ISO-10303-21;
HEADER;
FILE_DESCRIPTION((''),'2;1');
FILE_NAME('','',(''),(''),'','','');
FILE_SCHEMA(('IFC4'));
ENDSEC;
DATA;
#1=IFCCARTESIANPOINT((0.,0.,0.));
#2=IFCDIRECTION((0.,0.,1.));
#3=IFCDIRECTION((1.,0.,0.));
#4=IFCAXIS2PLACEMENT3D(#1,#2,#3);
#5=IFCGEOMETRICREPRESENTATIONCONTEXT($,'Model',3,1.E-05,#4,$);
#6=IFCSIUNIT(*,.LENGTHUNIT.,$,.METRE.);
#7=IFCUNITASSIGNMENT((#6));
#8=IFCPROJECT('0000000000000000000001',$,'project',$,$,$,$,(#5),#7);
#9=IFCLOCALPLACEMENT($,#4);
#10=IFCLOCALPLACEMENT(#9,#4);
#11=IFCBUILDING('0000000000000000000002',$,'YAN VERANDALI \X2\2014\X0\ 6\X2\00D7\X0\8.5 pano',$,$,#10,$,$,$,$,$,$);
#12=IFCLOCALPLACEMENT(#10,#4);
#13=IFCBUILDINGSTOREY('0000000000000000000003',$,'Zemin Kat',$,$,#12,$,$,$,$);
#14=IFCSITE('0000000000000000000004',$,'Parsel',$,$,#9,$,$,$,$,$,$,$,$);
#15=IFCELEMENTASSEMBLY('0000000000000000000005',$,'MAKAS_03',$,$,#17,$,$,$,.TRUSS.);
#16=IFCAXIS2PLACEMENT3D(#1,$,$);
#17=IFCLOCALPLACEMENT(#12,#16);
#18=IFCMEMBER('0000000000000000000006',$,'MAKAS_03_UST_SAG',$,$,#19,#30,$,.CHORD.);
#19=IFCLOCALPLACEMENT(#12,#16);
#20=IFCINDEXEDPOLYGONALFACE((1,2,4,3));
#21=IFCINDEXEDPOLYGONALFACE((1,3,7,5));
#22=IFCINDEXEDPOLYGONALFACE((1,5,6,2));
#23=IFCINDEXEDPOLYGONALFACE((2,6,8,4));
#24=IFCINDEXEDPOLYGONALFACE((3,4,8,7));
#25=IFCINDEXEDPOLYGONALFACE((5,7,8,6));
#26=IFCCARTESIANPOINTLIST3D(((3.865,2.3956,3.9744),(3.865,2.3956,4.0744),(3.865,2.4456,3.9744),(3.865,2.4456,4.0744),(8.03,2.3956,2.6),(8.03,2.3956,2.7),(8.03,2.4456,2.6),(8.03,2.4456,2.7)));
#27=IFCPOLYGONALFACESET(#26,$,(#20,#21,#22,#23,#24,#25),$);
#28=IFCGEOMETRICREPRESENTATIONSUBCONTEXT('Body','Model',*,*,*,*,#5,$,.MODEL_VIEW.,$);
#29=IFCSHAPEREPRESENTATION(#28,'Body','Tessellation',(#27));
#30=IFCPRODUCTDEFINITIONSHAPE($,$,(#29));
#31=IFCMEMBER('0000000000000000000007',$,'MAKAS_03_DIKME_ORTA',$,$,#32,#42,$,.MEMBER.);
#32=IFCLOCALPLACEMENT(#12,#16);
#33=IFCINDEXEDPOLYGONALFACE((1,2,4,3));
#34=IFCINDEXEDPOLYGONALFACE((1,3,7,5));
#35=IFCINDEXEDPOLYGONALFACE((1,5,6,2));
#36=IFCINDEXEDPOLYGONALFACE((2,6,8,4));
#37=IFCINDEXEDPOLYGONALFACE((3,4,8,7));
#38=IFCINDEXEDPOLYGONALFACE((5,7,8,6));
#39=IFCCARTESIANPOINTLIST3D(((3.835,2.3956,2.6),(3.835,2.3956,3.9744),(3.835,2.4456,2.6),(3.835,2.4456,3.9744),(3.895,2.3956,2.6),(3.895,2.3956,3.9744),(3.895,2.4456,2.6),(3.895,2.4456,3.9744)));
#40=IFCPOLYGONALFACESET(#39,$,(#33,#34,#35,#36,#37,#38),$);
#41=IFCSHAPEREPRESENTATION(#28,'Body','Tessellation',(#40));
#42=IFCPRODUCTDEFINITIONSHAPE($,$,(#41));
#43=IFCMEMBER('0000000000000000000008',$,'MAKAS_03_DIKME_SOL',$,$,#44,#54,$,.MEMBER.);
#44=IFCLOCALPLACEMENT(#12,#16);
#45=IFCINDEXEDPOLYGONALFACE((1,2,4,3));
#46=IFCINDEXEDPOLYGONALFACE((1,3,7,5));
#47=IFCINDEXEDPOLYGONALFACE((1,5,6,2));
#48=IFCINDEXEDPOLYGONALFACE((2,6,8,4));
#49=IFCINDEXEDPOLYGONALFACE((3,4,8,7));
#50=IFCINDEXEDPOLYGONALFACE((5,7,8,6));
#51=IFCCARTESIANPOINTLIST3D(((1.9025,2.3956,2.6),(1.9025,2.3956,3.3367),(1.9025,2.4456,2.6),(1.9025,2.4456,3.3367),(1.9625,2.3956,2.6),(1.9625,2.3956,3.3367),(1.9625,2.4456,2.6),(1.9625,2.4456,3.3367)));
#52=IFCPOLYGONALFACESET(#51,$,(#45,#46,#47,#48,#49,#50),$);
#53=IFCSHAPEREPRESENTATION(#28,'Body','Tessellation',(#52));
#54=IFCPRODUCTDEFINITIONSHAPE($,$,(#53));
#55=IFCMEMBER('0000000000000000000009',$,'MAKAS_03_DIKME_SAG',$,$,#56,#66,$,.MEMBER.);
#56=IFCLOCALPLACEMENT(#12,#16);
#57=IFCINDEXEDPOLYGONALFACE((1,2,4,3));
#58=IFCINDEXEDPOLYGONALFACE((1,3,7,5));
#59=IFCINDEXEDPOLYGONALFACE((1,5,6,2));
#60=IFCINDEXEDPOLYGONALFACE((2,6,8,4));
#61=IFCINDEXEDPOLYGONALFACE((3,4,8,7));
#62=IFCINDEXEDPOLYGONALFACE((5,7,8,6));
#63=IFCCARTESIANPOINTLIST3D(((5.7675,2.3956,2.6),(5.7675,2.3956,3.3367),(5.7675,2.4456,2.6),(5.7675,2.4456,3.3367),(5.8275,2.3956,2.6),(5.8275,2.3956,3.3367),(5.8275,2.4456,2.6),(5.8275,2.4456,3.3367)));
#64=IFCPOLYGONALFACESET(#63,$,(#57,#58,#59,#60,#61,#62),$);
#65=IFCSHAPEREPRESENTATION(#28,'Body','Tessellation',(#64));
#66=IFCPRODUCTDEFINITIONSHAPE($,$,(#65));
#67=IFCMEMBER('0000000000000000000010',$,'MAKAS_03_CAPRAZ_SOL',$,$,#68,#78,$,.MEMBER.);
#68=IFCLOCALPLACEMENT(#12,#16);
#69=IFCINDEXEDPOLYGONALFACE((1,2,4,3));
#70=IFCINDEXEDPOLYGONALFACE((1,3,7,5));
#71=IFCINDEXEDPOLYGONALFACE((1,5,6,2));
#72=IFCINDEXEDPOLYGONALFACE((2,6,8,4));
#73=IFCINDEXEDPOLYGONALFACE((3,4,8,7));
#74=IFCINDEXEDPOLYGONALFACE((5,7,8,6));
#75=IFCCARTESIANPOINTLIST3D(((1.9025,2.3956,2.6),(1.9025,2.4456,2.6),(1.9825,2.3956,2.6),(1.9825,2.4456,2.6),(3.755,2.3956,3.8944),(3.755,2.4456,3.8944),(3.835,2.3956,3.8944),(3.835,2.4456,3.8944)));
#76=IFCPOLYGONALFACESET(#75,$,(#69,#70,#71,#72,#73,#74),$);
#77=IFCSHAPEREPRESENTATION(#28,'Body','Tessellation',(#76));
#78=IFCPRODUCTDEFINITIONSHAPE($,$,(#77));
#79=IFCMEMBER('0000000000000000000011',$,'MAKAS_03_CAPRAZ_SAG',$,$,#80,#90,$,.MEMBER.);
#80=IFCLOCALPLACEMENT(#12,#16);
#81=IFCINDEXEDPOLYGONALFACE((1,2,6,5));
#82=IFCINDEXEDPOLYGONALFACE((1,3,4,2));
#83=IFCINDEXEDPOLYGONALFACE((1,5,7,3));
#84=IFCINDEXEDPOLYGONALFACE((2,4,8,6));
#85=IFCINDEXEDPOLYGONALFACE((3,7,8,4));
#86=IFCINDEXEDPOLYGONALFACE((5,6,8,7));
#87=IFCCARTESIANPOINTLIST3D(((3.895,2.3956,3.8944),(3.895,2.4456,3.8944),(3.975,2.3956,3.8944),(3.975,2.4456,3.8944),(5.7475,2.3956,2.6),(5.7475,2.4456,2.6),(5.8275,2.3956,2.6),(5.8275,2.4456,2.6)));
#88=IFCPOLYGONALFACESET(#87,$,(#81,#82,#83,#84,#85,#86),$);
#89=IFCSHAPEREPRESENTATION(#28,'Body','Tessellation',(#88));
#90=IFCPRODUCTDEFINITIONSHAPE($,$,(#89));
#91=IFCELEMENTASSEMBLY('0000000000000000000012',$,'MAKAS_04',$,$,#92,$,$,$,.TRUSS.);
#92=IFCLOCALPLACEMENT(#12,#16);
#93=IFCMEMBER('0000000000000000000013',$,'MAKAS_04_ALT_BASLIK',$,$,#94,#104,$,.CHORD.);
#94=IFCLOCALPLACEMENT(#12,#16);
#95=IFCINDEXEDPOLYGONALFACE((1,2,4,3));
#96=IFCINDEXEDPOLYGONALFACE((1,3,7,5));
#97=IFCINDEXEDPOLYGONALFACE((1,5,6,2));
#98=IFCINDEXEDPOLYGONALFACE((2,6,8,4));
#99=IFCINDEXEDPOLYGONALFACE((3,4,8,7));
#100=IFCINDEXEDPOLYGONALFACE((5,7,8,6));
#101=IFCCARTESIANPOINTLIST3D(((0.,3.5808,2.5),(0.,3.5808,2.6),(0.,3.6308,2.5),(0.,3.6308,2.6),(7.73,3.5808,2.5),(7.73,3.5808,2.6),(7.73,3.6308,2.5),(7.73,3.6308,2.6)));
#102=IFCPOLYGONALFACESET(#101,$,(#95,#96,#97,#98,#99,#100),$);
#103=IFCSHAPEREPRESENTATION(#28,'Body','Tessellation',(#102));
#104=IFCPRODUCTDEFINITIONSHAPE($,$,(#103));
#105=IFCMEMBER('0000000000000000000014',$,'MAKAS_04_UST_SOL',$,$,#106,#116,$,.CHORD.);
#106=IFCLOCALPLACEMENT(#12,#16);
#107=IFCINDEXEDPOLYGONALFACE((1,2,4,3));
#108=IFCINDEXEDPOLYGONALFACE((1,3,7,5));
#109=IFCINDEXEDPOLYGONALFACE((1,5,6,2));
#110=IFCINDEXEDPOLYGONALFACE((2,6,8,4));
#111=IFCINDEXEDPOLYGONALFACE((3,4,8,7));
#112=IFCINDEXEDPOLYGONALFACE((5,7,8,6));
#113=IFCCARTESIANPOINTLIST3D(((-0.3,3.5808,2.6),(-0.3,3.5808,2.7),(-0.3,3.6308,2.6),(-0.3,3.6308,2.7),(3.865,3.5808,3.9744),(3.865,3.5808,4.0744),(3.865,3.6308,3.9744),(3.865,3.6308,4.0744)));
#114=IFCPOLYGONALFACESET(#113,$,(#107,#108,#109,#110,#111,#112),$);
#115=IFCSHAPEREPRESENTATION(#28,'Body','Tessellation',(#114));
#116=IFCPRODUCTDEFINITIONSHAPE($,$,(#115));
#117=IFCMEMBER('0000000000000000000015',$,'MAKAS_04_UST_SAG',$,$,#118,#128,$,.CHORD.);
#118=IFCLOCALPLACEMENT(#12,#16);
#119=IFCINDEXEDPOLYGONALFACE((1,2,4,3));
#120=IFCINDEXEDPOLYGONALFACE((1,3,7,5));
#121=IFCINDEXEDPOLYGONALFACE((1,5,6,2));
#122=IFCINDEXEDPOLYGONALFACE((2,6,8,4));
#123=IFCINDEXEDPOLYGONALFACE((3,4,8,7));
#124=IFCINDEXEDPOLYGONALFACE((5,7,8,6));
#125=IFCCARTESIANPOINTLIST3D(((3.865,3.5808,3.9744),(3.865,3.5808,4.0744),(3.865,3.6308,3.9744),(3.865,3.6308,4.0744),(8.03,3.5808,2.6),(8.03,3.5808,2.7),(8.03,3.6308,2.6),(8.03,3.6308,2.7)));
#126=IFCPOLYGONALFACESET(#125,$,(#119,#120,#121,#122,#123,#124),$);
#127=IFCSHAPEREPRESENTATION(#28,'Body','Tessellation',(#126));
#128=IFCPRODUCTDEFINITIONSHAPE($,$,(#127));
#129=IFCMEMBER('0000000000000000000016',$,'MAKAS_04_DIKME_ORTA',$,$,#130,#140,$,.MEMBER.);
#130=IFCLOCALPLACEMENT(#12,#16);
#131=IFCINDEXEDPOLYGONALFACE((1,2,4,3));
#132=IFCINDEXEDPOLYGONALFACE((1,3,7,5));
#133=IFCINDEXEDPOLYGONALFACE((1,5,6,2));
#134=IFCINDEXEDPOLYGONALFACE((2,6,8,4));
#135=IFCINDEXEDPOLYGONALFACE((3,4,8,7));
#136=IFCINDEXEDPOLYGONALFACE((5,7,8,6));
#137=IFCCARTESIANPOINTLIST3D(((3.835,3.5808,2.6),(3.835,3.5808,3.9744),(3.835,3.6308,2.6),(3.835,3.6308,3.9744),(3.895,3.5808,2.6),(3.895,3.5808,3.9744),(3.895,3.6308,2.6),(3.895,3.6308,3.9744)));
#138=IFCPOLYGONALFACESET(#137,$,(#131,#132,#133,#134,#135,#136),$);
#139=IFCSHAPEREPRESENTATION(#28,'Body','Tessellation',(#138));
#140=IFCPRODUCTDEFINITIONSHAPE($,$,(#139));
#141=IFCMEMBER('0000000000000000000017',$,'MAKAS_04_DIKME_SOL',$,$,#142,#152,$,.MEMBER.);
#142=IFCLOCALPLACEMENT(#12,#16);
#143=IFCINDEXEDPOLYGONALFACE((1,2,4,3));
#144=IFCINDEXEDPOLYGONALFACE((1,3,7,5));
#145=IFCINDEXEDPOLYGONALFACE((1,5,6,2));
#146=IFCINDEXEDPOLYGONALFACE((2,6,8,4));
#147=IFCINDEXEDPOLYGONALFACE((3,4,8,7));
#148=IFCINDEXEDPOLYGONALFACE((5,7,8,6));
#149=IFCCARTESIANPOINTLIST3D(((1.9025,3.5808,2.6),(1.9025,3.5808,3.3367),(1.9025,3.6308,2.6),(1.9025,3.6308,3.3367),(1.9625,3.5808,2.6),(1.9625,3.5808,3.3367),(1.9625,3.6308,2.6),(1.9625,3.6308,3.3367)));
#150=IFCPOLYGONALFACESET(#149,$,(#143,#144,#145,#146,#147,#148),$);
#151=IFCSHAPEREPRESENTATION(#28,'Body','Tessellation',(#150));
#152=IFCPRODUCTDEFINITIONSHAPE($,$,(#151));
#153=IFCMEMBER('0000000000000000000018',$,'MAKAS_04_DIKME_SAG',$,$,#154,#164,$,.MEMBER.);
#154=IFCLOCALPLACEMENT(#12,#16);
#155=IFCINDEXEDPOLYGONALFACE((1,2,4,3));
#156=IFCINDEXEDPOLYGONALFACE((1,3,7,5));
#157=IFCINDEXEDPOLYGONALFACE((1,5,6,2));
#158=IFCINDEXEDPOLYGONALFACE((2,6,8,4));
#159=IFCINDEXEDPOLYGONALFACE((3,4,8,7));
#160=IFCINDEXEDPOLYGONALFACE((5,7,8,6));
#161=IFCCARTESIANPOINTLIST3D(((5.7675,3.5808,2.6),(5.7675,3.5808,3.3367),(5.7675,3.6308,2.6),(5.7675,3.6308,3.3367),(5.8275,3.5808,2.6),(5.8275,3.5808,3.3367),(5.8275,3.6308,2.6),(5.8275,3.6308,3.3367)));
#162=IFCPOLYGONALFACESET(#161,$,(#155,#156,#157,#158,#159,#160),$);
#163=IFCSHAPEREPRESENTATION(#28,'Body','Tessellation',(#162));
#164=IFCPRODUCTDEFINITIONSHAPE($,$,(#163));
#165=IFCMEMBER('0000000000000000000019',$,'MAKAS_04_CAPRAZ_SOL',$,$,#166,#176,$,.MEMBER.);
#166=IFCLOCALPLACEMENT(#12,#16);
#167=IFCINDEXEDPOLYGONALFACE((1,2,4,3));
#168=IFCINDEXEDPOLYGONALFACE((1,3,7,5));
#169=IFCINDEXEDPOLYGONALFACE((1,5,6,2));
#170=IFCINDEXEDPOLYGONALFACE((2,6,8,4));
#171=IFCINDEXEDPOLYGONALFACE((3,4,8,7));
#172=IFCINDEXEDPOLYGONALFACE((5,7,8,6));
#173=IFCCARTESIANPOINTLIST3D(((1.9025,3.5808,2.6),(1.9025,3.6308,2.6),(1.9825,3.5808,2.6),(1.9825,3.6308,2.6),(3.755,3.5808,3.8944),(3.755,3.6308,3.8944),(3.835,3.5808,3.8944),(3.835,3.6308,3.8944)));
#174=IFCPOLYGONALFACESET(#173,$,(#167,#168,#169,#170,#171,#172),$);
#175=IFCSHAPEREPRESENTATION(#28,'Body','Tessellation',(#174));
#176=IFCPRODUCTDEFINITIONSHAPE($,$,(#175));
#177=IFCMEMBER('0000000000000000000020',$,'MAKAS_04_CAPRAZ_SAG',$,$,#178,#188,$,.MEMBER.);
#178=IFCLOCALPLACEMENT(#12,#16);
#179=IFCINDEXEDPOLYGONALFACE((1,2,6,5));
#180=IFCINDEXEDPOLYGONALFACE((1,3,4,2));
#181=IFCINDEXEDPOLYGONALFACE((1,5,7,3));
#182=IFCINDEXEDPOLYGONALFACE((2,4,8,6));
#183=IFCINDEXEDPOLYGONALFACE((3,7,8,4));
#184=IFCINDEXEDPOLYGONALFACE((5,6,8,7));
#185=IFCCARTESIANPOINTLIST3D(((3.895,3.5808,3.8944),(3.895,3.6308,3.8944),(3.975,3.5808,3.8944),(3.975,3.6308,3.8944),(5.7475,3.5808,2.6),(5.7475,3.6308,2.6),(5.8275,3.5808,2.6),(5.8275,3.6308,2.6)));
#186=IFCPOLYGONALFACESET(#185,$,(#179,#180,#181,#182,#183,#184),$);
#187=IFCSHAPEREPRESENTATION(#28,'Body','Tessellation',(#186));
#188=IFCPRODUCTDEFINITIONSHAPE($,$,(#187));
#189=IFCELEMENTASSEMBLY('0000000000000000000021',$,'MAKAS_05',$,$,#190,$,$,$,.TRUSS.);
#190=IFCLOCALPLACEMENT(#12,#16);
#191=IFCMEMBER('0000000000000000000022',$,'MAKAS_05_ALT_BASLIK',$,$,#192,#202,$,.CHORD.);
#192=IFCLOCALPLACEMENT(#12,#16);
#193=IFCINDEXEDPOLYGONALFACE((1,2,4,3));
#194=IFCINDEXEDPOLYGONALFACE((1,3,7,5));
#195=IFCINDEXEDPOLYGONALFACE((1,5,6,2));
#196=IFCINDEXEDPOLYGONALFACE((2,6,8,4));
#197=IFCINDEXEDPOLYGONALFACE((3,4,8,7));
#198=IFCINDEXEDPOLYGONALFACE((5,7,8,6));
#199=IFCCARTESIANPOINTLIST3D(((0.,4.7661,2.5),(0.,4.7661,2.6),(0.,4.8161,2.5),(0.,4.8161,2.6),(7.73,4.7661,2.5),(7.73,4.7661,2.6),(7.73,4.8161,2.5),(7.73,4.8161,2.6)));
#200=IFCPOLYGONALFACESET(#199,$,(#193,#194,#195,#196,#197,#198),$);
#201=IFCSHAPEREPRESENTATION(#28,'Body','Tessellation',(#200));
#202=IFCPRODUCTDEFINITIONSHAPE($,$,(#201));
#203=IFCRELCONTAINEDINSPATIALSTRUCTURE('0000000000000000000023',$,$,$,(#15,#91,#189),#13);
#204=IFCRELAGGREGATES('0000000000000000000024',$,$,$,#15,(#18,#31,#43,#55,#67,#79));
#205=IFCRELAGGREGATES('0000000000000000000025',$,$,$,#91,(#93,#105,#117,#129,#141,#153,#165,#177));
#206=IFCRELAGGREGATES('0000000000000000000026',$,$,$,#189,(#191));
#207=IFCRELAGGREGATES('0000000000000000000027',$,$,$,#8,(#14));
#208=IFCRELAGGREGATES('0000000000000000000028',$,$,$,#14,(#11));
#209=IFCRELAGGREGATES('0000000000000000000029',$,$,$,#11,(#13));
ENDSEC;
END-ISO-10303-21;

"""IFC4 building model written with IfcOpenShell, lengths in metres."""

from ifc_helpers import new_model, si_unit, frame, origin_with_axes, place, context, subcontext, project, spatial, line, indexed_curve, outline, extrude, element, aggregate, save


model = new_model("IFC4")

# Units and contexts
model_context = context("Model", 3, precision=1e-05, world=origin_with_axes())
body_context = subcontext(model_context, "Body", "Model", "MODEL_VIEW")
ifc_project = project(units=[si_unit("LENGTHUNIT", "METRE")], contexts=[model_context])

# Site, building, storey
site_placement = place(None, origin_with_axes())
site = spatial("IfcSite", under=ifc_project, at=site_placement, Name="Parsel")
building_placement = place(site_placement, origin_with_axes())
building = spatial("IfcBuilding", under=site, at=building_placement, Name="YAN VERANDALI — 6×8.5 pano")
storey_placement = place(building_placement, origin_with_axes())
storey = spatial("IfcBuildingStorey", under=building, at=storey_placement, Name="Zemin Kat")

# Element assemblies, members
assembly_1_placement = place(storey_placement, origin_with_axes())
assembly_1 = element("IfcElementAssembly", 1, at=assembly_1_placement, inside=storey, Name="MAKAS_03", PredefinedType="TRUSS")
member_1_placement = place(assembly_1_placement, origin_with_axes())
member_1 = element("IfcMember", 2, at=member_1_placement, Name="MAKAS_03_UST_SAG", PredefinedType="CHORD", context=body_context, shape_type="SweptSolid", body=[
    extrude(outline(indexed_curve([(3.865, 3.9745), (8.03, 2.6), (8.03, 2.7), (3.865, 4.0744)], segments=[line(1, 2, 3, 4, 1)])), frame((0.0, 2.4456, 0.0), z_axis=(0.0, -1.0, 0.0), x_axis=(1.0, 0.0, 0.0)), (0.0, 0.0, 1.0), 0.05),
])
member_2_placement = place(assembly_1_placement, origin_with_axes())
member_2 = element("IfcMember", 3, at=member_2_placement, Name="MAKAS_03_DIKME_ORTA", PredefinedType="MEMBER", context=body_context, shape_type="SweptSolid", body=[
    extrude(outline(indexed_curve([(3.835, 2.6), (3.895, 2.6), (3.895, 3.9745), (3.835, 3.9745)], segments=[line(1, 2, 3, 4, 1)])), frame((0.0, 2.4456, 0.0), z_axis=(0.0, -1.0, 0.0), x_axis=(1.0, 0.0, 0.0)), (0.0, 0.0, 1.0), 0.05),
])
member_3_placement = place(assembly_1_placement, origin_with_axes())
member_3 = element("IfcMember", 4, at=member_3_placement, Name="MAKAS_03_DIKME_SOL", PredefinedType="MEMBER", context=body_context, shape_type="SweptSolid", body=[
    extrude(outline(indexed_curve([(1.9025, 2.6), (1.9625, 2.6), (1.9625, 3.3367), (1.9025, 3.3367)], segments=[line(1, 2, 3, 4, 1)])), frame((0.0, 2.4456, 0.0), z_axis=(0.0, -1.0, 0.0), x_axis=(1.0, 0.0, 0.0)), (0.0, 0.0, 1.0), 0.05),
])
member_4_placement = place(assembly_1_placement, origin_with_axes())
member_4 = element("IfcMember", 5, at=member_4_placement, Name="MAKAS_03_DIKME_SAG", PredefinedType="MEMBER", context=body_context, shape_type="SweptSolid", body=[
    extrude(outline(indexed_curve([(5.7675, 2.6), (5.8275, 2.6), (5.8275, 3.3367), (5.7675, 3.3367)], segments=[line(1, 2, 3, 4, 1)])), frame((0.0, 2.4456, 0.0), z_axis=(0.0, -1.0, 0.0), x_axis=(1.0, 0.0, 0.0)), (0.0, 0.0, 1.0), 0.05),
])
member_5_placement = place(assembly_1_placement, origin_with_axes())
member_5 = element("IfcMember", 6, at=member_5_placement, Name="MAKAS_03_CAPRAZ_SOL", PredefinedType="MEMBER", context=body_context, shape_type="SweptSolid", body=[
    extrude(outline(indexed_curve([(1.9025, 2.6), (1.9825, 2.6), (3.835, 3.8944), (3.755, 3.8944)], segments=[line(1, 2, 3, 4, 1)])), frame((0.0, 2.4456, 0.0), z_axis=(0.0, -1.0, 0.0), x_axis=(1.0, 0.0, 0.0)), (0.0, 0.0, 1.0), 0.05),
])
member_6_placement = place(assembly_1_placement, origin_with_axes())
member_6 = element("IfcMember", 7, at=member_6_placement, Name="MAKAS_03_CAPRAZ_SAG", PredefinedType="MEMBER", context=body_context, shape_type="SweptSolid", body=[
    extrude(outline(indexed_curve([(5.7475, 2.6), (5.8275, 2.6), (3.975, 3.8944), (3.895, 3.8944)], segments=[line(1, 2, 3, 4, 1)])), frame((0.0, 2.4456, 0.0), z_axis=(0.0, -1.0, 0.0), x_axis=(1.0, 0.0, 0.0)), (0.0, 0.0, 1.0), 0.05),
])
aggregate(assembly_1, [member_1, member_2, member_3, member_4, member_5, member_6])
assembly_2_placement = place(storey_placement, origin_with_axes())
assembly_2 = element("IfcElementAssembly", 8, at=assembly_2_placement, inside=storey, Name="MAKAS_04", PredefinedType="TRUSS")
member_7_placement = place(assembly_2_placement, origin_with_axes())
member_7 = element("IfcMember", 9, at=member_7_placement, Name="MAKAS_04_ALT_BASLIK", PredefinedType="CHORD", context=body_context, shape_type="SweptSolid", body=[
    extrude(outline(indexed_curve([(0.0, 2.5), (7.73, 2.5), (7.73, 2.6), (0.0, 2.6)], segments=[line(1, 2, 3, 4, 1)])), frame((0.0, 3.6308, 0.0), z_axis=(0.0, -1.0, 0.0), x_axis=(1.0, 0.0, 0.0)), (0.0, 0.0, 1.0), 0.05),
])
member_8_placement = place(assembly_2_placement, origin_with_axes())
member_8 = element("IfcMember", 10, at=member_8_placement, Name="MAKAS_04_UST_SOL", PredefinedType="CHORD", context=body_context, shape_type="SweptSolid", body=[
    extrude(outline(indexed_curve([(-0.3, 2.6), (3.865, 3.9745), (3.865, 4.0744), (-0.3, 2.7)], segments=[line(1, 2, 3, 4, 1)])), frame((0.0, 3.6308, 0.0), z_axis=(0.0, -1.0, 0.0), x_axis=(1.0, 0.0, 0.0)), (0.0, 0.0, 1.0), 0.05),
])
member_9_placement = place(assembly_2_placement, origin_with_axes())
member_9 = element("IfcMember", 11, at=member_9_placement, Name="MAKAS_04_UST_SAG", PredefinedType="CHORD", context=body_context, shape_type="SweptSolid", body=[
    extrude(outline(indexed_curve([(3.865, 3.9745), (8.03, 2.6), (8.03, 2.7), (3.865, 4.0744)], segments=[line(1, 2, 3, 4, 1)])), frame((0.0, 3.6308, 0.0), z_axis=(0.0, -1.0, 0.0), x_axis=(1.0, 0.0, 0.0)), (0.0, 0.0, 1.0), 0.05),
])
member_10_placement = place(assembly_2_placement, origin_with_axes())
member_10 = element("IfcMember", 12, at=member_10_placement, Name="MAKAS_04_DIKME_ORTA", PredefinedType="MEMBER", context=body_context, shape_type="SweptSolid", body=[
    extrude(outline(indexed_curve([(3.835, 2.6), (3.895, 2.6), (3.895, 3.9745), (3.835, 3.9745)], segments=[line(1, 2, 3, 4, 1)])), frame((0.0, 3.6308, 0.0), z_axis=(0.0, -1.0, 0.0), x_axis=(1.0, 0.0, 0.0)), (0.0, 0.0, 1.0), 0.05),
])
member_11_placement = place(assembly_2_placement, origin_with_axes())
member_11 = element("IfcMember", 13, at=member_11_placement, Name="MAKAS_04_DIKME_SOL", PredefinedType="MEMBER", context=body_context, shape_type="SweptSolid", body=[
    extrude(outline(indexed_curve([(1.9025, 2.6), (1.9625, 2.6), (1.9625, 3.3367), (1.9025, 3.3367)], segments=[line(1, 2, 3, 4, 1)])), frame((0.0, 3.6308, 0.0), z_axis=(0.0, -1.0, 0.0), x_axis=(1.0, 0.0, 0.0)), (0.0, 0.0, 1.0), 0.05),
])
member_12_placement = place(assembly_2_placement, origin_with_axes())
member_12 = element("IfcMember", 14, at=member_12_placement, Name="MAKAS_04_DIKME_SAG", PredefinedType="MEMBER", context=body_context, shape_type="SweptSolid", body=[
    extrude(outline(indexed_curve([(5.7675, 2.6), (5.8275, 2.6), (5.8275, 3.3367), (5.7675, 3.3367)], segments=[line(1, 2, 3, 4, 1)])), frame((0.0, 3.6308, 0.0), z_axis=(0.0, -1.0, 0.0), x_axis=(1.0, 0.0, 0.0)), (0.0, 0.0, 1.0), 0.05),
])
member_13_placement = place(assembly_2_placement, origin_with_axes())
member_13 = element("IfcMember", 15, at=member_13_placement, Name="MAKAS_04_CAPRAZ_SOL", PredefinedType="MEMBER", context=body_context, shape_type="SweptSolid", body=[
    extrude(outline(indexed_curve([(1.9025, 2.6), (1.9825, 2.6), (3.835, 3.8944), (3.755, 3.8944)], segments=[line(1, 2, 3, 4, 1)])), frame((0.0, 3.6308, 0.0), z_axis=(0.0, -1.0, 0.0), x_axis=(1.0, 0.0, 0.0)), (0.0, 0.0, 1.0), 0.05),
])
member_14_placement = place(assembly_2_placement, origin_with_axes())
member_14 = element("IfcMember", 16, at=member_14_placement, Name="MAKAS_04_CAPRAZ_SAG", PredefinedType="MEMBER", context=body_context, shape_type="SweptSolid", body=[
    extrude(outline(indexed_curve([(5.7475, 2.6), (5.8275, 2.6), (3.975, 3.8944), (3.895, 3.8944)], segments=[line(1, 2, 3, 4, 1)])), frame((0.0, 3.6308, 0.0), z_axis=(0.0, -1.0, 0.0), x_axis=(1.0, 0.0, 0.0)), (0.0, 0.0, 1.0), 0.05),
])
aggregate(assembly_2, [member_7, member_8, member_9, member_10, member_11, member_12, member_13, member_14])
assembly_3_placement = place(storey_placement, origin_with_axes())
assembly_3 = element("IfcElementAssembly", 17, at=assembly_3_placement, inside=storey, Name="MAKAS_05", PredefinedType="TRUSS")
member_15_placement = place(assembly_3_placement, origin_with_axes())
member_15 = element("IfcMember", 18, at=member_15_placement, Name="MAKAS_05_ALT_BASLIK", PredefinedType="CHORD", context=body_context, shape_type="SweptSolid", body=[
    extrude(outline(indexed_curve([(0.0, 2.5), (7.73, 2.5), (7.73, 2.6), (0.0, 2.6)], segments=[line(1, 2, 3, 4, 1)])), frame((0.0, 4.8161, 0.0), z_axis=(0.0, -1.0, 0.0), x_axis=(1.0, 0.0, 0.0)), (0.0, 0.0, 1.0), 0.05),
])
aggregate(assembly_3, [member_15])

save(model, "model.ifc")
